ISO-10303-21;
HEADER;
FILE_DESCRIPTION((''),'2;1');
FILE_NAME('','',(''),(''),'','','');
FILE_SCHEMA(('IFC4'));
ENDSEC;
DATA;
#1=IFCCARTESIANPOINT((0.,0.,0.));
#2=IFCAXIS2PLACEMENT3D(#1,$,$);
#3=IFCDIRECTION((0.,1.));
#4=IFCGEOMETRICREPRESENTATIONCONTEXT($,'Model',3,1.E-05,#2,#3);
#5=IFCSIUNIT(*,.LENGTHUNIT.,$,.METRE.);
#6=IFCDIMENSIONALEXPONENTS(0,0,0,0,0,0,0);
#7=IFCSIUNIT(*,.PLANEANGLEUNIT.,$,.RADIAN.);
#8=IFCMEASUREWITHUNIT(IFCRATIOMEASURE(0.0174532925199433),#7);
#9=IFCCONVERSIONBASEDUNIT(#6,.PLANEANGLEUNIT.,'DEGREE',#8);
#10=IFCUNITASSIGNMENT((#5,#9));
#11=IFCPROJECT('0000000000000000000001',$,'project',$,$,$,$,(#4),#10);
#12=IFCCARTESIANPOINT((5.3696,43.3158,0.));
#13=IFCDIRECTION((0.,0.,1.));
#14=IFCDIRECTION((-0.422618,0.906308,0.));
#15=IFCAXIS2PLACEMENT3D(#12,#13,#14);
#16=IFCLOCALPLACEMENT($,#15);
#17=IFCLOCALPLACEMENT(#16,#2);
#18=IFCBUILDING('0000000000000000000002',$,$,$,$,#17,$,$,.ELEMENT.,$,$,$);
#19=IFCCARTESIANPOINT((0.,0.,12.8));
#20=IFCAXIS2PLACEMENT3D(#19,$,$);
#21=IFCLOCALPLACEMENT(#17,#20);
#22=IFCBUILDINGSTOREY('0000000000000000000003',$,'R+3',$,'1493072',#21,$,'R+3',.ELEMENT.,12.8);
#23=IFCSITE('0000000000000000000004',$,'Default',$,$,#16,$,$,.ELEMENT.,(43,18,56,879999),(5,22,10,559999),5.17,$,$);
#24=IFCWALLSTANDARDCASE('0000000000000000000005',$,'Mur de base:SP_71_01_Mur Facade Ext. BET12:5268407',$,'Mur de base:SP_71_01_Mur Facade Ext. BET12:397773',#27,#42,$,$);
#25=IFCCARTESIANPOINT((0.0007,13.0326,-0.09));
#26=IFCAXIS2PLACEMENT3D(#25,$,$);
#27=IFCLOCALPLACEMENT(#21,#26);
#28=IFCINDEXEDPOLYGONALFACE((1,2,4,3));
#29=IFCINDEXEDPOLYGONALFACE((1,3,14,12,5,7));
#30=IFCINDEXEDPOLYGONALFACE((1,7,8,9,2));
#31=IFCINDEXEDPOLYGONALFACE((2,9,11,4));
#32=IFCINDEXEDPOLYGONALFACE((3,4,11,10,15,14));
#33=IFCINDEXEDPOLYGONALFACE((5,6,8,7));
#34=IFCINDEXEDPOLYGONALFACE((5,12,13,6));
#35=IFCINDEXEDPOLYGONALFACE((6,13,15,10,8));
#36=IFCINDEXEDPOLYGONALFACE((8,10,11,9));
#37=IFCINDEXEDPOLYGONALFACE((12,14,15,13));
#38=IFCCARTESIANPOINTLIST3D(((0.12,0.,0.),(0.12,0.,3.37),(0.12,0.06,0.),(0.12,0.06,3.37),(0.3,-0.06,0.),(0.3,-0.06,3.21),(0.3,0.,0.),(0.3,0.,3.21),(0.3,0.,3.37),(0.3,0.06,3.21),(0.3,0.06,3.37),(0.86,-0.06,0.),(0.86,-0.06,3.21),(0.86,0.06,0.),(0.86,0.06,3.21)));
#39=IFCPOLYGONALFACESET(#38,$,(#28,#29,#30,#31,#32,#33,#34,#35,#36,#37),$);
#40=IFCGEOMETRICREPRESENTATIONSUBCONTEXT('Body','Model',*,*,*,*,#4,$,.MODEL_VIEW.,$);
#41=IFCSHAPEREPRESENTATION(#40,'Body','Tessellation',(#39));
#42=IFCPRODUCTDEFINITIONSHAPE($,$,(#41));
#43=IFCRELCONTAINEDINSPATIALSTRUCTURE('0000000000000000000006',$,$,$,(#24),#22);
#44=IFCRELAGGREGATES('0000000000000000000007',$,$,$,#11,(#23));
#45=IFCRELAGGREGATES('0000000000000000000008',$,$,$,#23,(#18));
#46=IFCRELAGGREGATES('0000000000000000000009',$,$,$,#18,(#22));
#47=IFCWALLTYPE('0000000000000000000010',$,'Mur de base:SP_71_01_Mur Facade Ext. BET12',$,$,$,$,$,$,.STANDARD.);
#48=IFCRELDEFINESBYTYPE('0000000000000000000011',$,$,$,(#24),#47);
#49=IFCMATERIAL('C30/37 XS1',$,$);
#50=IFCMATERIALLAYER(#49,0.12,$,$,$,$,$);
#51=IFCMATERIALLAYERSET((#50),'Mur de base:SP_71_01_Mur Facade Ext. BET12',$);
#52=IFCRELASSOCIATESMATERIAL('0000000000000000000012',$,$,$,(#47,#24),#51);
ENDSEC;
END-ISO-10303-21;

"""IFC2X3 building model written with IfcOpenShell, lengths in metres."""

from ifc_helpers import new_model, entity, si_unit, converted_unit, direction, frame, origin, place, context, subcontext, project, spatial, polyline, outline, extrude, clip, bounded_halfspace, material, layer, layer_set, layer_usage, type_object, element, save


model = new_model("IFC2X3")

# Units and contexts
model_context = context("Model", 3, precision=1e-05, world=origin(), true_north=direction((0.0, 1.0)))
body_context = subcontext(model_context, "Body", "Model", "MODEL_VIEW")
ifc_project = project(units=[si_unit("LENGTHUNIT", "METRE"), converted_unit("PLANEANGLEUNIT", "DEGREE", entity("IfcRatioMeasure", 0.0174532925199433), si_unit("PLANEANGLEUNIT", "RADIAN"), dimensions=[0, 0, 0, 0, 0, 0, 0])], contexts=[model_context])

# Site, building, storey
site_placement = place(None, frame((5.3696, 43.3158, 0.0), z_axis=(0.0, 0.0, 1.0), x_axis=(-0.422618, 0.906308, 0.0)))
site = spatial("IfcSite", under=ifc_project, at=site_placement, Name="Default", CompositionType="ELEMENT", RefLatitude=(43, 18, 56, 879999), RefLongitude=(5, 22, 10, 559999), RefElevation=5.17)
building_placement = place(site_placement, origin())
building = spatial("IfcBuilding", under=site, at=building_placement, CompositionType="ELEMENT")
storey_placement = place(building_placement, frame((0.0, 0.0, 12.8)))
storey = spatial("IfcBuildingStorey", under=building, at=storey_placement, Name="R+3", ObjectType="1493072", LongName="R+3", CompositionType="ELEMENT", Elevation=12.8)

# Shared definitions
ifc_material_1 = material(Name="C30/37 XS1")

# Wall
ifc_layer_1 = layer(ifc_material_1, 0.12)
ifc_layer_set_1 = layer_set([ifc_layer_1], Name="Mur de base:SP_71_01_Mur Facade Ext. BET12")
wall_type_1 = type_object("IfcWallType", Name="Mur de base:SP_71_01_Mur Facade Ext. BET12", PredefinedType="STANDARD", material=ifc_layer_set_1)
ifc_layer_usage_1 = layer_usage(ifc_layer_set_1, "AXIS2", "NEGATIVE", 0.06)
wall_1_placement = place(storey_placement, frame((0.0007, 13.0326, -0.09)))
element("IfcWallStandardCase", 1, at=wall_1_placement, inside=storey, type_object=wall_type_1, material=ifc_layer_usage_1, Name="Mur de base:SP_71_01_Mur Facade Ext. BET12:5268407", ObjectType="Mur de base:SP_71_01_Mur Facade Ext. BET12:397773", context=body_context, shape_type="Clipping", body=[
    clip(clip(extrude(outline(polyline([(0.86, -0.06), (0.86, 0.06), (0.12, 0.06), (0.12, 0.0), (0.3, 0.0), (0.3, -0.06), (0.86, -0.06)])), origin(), (0.0, 0.0, 1.0), 3.37), bounded_halfspace(frame((0.3, 0.0, 3.21), z_axis=(0.0, 0.0, -1.0), x_axis=(1.0, 0.0, 0.0)), True, frame((0.3, 0.0, 3.21), z_axis=(0.0, 0.0, -1.0), x_axis=(1.0, 0.0, 0.0)), polyline([(0.0, 0.0), (0.0, -0.06), (0.56, -0.06), (0.56, 0.06), (0.0, 0.06), (0.0, 0.0)]))), bounded_halfspace(frame((0.3, -0.06, 3.21), z_axis=(-1.0, 0.0, 0.0), x_axis=(0.0, 0.0, 1.0)), True, frame((0.3, -0.06, 3.21), z_axis=(-1.0, 0.0, 0.0), x_axis=(0.0, 0.0, 1.0)), polyline([(0.0, 0.0), (0.16, 0.0), (0.16, 0.12), (0.0, 0.12), (0.0, 0.06), (0.0, 0.0)]))),
])

save(model, "model.ifc")
